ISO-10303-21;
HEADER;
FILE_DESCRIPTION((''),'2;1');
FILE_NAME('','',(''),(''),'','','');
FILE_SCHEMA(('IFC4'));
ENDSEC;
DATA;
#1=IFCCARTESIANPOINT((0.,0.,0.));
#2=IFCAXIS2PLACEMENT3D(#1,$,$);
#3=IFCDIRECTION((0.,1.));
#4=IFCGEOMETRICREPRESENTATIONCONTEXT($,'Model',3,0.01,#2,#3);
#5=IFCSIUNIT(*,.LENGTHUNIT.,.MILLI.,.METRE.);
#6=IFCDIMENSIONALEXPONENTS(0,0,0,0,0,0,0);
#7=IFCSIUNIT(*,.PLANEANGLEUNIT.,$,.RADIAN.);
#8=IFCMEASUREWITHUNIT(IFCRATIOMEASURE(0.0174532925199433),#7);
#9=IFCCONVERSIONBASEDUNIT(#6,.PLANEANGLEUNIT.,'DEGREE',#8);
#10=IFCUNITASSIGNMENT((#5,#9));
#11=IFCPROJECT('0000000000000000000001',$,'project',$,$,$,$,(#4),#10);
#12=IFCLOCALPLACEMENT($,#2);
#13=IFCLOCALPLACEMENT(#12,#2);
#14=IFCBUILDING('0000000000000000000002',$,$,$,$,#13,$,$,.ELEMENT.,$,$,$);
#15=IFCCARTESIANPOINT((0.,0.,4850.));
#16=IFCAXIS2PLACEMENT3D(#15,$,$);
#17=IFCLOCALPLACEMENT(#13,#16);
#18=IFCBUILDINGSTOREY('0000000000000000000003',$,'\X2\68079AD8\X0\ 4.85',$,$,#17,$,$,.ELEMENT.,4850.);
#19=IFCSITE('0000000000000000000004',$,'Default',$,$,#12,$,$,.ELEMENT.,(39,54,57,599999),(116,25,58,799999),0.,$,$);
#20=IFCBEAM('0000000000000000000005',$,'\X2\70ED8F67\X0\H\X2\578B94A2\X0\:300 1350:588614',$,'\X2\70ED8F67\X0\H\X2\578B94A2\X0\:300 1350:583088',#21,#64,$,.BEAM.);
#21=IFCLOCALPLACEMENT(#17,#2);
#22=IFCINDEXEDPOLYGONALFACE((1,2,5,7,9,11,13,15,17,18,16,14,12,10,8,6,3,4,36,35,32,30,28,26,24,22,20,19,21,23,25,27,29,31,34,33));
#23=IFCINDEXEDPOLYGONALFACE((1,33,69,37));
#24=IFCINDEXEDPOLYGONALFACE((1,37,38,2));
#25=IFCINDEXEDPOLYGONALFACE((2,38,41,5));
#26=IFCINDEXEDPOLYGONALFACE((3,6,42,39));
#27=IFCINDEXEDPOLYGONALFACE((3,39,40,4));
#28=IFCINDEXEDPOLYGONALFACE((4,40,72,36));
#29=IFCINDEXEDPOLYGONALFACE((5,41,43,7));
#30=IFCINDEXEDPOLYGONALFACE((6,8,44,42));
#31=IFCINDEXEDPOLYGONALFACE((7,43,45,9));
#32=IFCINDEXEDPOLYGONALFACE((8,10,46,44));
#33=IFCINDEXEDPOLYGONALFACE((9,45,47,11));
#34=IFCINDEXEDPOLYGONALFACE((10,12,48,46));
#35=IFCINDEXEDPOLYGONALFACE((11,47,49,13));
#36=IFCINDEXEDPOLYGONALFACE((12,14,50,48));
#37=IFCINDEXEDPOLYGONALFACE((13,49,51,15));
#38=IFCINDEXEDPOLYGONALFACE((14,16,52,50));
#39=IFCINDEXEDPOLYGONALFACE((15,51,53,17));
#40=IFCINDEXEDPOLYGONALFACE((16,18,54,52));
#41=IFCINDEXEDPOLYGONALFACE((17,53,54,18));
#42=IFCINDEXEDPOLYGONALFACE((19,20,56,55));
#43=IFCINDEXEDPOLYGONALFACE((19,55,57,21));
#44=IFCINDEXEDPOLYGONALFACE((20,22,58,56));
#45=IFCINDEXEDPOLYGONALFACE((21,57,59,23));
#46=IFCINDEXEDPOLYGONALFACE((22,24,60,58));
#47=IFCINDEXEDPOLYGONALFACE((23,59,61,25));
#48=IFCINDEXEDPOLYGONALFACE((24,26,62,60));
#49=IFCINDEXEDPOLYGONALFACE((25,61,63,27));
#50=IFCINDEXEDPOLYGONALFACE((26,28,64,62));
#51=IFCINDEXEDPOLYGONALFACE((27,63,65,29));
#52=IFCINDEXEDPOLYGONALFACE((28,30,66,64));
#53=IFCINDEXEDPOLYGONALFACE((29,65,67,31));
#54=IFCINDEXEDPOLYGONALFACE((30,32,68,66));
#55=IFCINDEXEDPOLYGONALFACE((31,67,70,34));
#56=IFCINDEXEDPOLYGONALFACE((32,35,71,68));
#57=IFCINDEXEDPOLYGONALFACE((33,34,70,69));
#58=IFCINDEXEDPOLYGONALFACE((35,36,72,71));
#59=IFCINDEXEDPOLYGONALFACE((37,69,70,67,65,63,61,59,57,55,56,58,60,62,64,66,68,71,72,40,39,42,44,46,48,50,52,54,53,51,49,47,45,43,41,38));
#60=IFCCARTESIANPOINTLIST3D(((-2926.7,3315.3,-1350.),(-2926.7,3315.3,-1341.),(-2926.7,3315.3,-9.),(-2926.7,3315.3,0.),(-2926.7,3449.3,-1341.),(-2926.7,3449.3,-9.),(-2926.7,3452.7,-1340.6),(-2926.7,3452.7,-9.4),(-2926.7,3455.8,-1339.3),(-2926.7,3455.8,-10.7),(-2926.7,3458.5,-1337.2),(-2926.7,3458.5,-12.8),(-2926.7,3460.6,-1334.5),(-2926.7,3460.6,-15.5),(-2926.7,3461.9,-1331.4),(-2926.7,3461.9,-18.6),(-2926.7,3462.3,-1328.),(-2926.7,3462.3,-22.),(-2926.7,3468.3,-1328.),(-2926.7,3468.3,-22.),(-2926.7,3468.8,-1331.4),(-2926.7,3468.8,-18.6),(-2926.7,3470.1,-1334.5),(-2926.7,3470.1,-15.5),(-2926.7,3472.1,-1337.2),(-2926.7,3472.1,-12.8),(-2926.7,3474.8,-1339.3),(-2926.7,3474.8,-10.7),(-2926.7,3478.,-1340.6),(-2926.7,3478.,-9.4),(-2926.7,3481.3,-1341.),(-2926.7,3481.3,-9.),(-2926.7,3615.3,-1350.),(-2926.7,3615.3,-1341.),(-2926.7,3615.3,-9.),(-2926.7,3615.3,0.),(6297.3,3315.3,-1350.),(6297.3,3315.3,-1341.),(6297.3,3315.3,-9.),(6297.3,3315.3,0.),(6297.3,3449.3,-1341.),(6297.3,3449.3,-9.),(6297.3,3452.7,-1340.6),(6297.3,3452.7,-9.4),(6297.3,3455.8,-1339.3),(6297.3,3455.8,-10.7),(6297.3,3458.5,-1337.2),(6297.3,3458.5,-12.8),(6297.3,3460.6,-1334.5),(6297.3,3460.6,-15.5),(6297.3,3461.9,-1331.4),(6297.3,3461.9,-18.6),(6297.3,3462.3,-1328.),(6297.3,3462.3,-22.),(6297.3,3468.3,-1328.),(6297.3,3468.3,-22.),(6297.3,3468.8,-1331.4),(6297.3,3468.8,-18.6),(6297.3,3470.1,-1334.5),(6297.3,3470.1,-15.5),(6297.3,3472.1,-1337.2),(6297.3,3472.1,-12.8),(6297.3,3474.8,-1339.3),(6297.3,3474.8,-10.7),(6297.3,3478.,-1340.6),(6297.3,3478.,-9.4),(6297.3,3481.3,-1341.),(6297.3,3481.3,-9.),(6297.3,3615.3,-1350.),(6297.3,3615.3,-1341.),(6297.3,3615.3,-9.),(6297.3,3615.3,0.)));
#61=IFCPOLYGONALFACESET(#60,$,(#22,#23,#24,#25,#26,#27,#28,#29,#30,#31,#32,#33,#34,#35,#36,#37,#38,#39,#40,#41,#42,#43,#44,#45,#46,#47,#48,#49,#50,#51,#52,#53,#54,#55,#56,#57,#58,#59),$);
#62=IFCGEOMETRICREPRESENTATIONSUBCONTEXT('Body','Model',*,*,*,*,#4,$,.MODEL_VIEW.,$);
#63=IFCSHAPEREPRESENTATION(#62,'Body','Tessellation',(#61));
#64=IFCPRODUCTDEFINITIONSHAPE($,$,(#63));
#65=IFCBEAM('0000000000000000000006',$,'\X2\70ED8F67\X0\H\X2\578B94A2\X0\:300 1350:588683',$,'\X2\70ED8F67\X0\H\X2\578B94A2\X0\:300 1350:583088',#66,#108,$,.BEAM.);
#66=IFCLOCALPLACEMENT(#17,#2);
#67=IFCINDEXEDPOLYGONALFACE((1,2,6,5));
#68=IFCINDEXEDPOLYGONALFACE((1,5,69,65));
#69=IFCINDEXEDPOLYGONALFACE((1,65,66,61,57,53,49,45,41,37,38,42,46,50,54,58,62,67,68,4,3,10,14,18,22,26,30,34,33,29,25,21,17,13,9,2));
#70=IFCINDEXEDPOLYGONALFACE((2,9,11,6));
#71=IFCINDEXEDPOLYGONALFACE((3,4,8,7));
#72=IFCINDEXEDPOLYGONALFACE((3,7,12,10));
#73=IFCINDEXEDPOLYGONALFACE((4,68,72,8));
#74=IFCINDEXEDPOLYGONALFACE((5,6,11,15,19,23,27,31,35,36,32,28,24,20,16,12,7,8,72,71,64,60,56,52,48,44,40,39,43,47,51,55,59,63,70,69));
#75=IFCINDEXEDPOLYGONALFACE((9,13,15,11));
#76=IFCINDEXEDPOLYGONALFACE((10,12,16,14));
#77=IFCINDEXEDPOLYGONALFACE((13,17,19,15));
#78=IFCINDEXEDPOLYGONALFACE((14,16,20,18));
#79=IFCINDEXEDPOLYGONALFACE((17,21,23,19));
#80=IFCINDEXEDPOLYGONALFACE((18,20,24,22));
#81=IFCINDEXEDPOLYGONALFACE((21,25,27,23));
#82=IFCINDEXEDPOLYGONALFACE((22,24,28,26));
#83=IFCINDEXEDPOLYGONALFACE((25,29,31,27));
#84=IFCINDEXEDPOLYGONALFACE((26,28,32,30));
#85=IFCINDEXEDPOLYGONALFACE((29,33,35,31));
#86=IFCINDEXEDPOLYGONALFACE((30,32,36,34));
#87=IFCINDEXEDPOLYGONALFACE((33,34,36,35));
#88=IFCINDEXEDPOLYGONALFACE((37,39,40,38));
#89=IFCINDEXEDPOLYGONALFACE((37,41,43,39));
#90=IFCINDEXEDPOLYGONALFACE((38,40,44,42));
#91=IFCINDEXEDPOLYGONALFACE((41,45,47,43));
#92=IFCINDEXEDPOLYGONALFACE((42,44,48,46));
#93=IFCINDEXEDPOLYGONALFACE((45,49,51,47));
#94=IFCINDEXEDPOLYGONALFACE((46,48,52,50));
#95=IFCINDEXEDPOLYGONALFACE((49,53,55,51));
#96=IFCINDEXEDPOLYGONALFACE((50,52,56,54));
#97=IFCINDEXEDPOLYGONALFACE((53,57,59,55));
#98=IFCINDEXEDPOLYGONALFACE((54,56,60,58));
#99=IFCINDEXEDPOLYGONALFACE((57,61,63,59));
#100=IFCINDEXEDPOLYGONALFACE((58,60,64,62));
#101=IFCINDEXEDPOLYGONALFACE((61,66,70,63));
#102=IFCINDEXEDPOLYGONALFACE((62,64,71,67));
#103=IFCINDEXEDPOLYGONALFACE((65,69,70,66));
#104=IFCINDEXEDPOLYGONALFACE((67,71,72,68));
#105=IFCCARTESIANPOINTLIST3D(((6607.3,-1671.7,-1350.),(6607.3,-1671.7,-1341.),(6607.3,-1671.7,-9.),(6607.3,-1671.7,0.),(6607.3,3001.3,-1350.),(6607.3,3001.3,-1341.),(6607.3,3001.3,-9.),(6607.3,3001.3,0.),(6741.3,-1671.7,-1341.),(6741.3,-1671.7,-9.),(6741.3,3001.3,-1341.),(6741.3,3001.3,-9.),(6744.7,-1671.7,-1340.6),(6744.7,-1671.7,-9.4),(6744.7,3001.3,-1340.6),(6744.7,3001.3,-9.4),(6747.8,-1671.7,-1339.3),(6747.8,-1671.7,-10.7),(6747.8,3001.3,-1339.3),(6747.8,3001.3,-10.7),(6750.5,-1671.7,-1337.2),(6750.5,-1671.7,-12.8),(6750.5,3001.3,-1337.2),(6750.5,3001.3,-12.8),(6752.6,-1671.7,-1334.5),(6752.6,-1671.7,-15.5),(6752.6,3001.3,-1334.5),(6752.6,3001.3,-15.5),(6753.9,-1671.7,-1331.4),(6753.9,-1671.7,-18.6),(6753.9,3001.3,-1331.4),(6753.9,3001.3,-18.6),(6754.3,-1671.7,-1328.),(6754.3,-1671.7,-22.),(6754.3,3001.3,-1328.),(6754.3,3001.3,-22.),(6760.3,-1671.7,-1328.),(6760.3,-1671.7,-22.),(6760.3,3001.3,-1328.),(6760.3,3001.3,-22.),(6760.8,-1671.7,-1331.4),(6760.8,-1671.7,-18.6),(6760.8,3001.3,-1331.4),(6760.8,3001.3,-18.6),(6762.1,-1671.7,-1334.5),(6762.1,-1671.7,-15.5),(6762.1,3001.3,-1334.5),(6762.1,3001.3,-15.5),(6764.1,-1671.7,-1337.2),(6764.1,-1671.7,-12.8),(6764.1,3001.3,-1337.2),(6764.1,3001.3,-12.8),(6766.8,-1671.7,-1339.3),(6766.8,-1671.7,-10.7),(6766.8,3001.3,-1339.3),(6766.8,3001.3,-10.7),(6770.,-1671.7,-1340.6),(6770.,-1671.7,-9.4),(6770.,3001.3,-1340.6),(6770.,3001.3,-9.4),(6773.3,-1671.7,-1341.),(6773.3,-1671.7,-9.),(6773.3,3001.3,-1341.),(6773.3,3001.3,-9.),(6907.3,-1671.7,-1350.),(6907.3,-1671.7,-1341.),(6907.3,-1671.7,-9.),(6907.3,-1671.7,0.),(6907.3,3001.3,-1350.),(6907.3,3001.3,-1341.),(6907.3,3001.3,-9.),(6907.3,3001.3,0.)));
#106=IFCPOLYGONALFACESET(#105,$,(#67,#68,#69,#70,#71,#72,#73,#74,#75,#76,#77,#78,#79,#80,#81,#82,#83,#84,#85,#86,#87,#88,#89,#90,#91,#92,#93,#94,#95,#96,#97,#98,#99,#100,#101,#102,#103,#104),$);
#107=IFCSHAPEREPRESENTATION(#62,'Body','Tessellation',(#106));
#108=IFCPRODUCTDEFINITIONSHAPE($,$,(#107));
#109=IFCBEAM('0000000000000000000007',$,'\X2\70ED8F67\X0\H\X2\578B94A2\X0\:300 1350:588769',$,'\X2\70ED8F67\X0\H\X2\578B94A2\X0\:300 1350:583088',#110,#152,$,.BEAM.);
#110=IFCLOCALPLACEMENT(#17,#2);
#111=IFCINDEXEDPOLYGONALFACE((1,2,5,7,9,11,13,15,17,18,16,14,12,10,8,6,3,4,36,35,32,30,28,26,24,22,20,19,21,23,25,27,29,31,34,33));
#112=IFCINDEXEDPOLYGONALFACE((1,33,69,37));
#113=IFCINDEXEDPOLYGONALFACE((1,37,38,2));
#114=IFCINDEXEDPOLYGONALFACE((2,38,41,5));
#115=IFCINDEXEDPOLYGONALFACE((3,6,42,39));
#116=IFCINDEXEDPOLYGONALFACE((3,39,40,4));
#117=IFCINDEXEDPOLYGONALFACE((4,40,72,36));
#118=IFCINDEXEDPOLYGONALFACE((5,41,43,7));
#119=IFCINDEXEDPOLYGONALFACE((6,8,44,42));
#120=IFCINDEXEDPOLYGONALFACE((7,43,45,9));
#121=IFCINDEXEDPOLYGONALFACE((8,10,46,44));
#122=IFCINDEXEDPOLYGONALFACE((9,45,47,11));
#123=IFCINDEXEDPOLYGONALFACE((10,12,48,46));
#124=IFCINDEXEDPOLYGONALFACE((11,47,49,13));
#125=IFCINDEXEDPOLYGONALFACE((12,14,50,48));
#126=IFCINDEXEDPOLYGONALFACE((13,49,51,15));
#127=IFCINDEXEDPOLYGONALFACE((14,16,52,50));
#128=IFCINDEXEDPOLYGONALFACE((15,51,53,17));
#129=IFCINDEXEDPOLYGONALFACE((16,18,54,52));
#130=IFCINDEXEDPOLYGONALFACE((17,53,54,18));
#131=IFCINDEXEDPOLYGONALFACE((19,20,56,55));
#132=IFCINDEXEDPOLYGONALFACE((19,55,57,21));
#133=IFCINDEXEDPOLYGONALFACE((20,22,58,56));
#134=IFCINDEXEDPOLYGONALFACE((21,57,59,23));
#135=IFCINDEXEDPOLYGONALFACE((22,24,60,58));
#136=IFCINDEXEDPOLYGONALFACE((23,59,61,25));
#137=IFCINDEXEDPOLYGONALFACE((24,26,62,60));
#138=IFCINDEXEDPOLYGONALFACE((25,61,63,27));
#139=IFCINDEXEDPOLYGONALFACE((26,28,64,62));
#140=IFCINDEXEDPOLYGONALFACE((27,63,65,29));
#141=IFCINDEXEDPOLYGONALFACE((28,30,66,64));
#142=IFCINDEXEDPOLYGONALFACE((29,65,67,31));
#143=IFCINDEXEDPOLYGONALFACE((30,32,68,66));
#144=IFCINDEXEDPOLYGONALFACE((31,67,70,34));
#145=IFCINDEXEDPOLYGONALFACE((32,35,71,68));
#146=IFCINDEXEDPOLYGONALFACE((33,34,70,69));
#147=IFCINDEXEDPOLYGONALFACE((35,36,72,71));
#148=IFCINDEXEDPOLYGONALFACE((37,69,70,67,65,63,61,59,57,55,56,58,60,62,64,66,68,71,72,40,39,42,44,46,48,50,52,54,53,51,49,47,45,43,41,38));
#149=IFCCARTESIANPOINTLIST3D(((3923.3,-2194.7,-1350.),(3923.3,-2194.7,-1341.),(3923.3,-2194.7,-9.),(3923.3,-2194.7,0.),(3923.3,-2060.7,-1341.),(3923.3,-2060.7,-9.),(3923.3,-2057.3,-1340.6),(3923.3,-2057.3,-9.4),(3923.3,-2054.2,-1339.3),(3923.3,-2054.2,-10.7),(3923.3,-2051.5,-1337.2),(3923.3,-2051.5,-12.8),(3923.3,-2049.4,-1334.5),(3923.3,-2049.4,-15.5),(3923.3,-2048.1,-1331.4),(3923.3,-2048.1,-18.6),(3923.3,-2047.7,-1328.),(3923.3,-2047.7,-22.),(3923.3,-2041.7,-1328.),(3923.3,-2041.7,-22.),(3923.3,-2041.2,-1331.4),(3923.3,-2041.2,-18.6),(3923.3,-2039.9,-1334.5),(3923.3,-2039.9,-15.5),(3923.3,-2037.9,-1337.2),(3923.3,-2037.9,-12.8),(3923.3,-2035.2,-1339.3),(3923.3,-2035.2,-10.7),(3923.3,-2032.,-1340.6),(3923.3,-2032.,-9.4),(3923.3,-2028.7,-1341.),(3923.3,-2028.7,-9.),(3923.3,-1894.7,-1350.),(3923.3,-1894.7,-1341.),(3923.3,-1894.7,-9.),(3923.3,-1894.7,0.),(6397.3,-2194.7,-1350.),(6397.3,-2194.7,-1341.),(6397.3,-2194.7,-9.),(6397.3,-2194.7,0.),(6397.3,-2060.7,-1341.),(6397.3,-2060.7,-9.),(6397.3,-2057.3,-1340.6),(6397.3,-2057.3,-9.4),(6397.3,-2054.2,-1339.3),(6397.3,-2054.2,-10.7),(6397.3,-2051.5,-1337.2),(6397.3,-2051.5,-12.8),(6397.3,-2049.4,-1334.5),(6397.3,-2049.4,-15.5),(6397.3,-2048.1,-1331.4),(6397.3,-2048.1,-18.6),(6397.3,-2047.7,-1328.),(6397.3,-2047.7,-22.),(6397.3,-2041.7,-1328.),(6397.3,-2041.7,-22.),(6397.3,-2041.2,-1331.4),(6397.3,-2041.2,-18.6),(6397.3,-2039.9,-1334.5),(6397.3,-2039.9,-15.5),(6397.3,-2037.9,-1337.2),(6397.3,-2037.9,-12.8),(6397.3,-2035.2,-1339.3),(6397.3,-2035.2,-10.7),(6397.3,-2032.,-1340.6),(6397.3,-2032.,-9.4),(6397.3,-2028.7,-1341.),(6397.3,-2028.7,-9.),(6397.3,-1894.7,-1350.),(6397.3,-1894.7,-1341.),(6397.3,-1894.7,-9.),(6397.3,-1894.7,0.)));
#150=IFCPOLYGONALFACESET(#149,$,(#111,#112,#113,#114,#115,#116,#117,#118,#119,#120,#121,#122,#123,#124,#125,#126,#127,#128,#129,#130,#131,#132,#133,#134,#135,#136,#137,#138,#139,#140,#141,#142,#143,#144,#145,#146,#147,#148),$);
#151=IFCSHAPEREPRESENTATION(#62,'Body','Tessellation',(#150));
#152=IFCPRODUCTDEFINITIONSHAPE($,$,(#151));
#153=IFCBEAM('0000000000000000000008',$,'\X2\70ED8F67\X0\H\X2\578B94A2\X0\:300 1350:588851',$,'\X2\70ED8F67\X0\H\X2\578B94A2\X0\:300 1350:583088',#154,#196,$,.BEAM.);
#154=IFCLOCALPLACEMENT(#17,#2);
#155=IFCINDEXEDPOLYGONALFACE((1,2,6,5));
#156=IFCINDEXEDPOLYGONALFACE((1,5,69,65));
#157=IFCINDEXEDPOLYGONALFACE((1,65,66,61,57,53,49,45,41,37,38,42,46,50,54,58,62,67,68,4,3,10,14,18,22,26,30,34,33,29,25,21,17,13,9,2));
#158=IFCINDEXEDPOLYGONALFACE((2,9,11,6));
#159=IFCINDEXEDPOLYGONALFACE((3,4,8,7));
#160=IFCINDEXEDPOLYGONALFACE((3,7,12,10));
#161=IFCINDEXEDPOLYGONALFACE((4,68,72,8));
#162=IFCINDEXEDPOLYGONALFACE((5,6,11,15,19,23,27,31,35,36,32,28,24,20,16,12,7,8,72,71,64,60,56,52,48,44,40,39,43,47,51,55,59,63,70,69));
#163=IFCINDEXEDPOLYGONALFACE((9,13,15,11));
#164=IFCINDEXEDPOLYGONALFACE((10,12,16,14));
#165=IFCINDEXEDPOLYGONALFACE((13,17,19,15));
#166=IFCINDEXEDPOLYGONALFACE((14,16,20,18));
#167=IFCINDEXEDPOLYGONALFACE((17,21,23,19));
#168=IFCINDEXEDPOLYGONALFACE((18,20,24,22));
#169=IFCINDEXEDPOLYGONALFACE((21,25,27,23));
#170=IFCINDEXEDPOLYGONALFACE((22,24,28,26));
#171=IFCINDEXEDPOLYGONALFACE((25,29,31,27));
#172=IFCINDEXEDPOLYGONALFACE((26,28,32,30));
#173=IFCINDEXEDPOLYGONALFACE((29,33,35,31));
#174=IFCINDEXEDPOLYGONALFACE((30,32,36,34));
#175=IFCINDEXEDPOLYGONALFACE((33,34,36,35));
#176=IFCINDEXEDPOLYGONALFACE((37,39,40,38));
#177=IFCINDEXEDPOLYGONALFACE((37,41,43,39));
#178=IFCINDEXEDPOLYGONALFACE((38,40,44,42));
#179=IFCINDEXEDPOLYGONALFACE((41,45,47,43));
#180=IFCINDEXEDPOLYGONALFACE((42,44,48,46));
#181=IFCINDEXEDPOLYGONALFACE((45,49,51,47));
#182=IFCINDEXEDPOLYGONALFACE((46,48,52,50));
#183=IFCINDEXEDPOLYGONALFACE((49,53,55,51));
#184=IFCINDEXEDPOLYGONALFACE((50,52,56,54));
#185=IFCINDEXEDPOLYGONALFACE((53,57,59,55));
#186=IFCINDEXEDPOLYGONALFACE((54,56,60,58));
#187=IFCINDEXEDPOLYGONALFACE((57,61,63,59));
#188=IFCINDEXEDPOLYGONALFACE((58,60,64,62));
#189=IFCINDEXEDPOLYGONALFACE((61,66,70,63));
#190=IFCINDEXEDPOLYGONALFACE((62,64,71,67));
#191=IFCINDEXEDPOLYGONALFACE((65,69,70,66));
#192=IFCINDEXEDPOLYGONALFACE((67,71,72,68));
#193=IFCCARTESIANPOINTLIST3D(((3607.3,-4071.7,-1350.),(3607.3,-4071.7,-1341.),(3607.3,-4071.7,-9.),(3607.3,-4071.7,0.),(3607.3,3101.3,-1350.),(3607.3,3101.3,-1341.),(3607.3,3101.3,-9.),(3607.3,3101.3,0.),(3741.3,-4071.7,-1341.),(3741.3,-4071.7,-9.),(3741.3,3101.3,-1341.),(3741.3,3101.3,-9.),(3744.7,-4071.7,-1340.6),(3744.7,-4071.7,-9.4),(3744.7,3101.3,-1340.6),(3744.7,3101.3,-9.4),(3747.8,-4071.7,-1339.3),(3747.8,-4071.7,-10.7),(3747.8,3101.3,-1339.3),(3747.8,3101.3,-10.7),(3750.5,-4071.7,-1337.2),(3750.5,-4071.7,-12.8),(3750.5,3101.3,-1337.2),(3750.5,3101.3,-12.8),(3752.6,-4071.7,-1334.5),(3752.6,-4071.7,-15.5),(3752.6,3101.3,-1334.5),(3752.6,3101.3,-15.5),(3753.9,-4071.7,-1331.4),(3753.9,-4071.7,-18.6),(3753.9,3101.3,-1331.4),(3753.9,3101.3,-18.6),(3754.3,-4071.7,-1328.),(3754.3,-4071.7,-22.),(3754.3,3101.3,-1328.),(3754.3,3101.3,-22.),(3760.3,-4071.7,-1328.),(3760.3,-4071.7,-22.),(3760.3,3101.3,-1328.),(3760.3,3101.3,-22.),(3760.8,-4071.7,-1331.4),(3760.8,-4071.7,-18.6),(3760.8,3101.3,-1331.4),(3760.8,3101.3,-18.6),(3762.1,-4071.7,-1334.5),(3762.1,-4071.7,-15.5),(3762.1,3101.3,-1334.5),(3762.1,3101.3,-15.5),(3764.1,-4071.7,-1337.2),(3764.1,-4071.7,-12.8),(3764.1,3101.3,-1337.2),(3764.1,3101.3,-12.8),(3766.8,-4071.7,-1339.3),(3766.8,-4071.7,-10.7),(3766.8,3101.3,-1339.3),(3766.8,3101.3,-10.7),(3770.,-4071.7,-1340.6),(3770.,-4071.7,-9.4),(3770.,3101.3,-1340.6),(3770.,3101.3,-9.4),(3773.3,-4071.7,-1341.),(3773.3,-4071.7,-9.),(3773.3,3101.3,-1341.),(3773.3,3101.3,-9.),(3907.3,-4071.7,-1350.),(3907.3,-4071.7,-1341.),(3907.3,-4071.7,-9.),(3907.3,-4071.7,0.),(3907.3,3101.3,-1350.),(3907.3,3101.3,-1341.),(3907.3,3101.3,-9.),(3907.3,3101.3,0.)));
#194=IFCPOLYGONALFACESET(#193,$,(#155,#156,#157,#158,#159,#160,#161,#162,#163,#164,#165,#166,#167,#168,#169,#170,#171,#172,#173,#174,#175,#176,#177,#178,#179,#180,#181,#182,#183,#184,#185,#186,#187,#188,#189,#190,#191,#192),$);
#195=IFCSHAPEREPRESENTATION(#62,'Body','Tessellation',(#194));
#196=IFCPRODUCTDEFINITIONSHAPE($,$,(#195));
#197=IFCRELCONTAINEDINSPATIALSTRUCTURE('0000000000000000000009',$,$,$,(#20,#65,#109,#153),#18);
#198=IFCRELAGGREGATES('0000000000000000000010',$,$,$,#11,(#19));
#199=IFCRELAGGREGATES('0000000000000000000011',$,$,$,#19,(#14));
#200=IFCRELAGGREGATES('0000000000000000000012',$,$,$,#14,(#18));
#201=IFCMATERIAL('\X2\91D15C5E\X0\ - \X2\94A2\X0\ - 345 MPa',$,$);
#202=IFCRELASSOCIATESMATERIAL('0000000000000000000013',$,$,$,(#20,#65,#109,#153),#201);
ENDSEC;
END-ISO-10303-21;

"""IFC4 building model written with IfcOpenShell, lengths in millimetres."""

from ifc_helpers import new_model, entity, si_unit, converted_unit, direction, frame, frame_2d, origin, place, context, subcontext, project, spatial, i_section, extrude, material, element, save


model = new_model("IFC4")

# Units and contexts
model_context = context("Model", 3, precision=0.01, world=origin(), true_north=direction((0.0, 1.0)))
body_context = subcontext(model_context, "Body", "Model", "MODEL_VIEW")
ifc_project = project(units=[si_unit("LENGTHUNIT", "METRE", prefix="MILLI"), converted_unit("PLANEANGLEUNIT", "DEGREE", entity("IfcRatioMeasure", 0.0174532925199433), si_unit("PLANEANGLEUNIT", "RADIAN"), dimensions=[0, 0, 0, 0, 0, 0, 0])], contexts=[model_context])

# Site, building, storey
site_placement = place(None, origin())
site = spatial("IfcSite", under=ifc_project, at=site_placement, Name="Default", CompositionType="ELEMENT", RefLatitude=(39, 54, 57, 599999), RefLongitude=(116, 25, 58, 799999), RefElevation=0.0)
building_placement = place(site_placement, origin())
building = spatial("IfcBuilding", under=site, at=building_placement, CompositionType="ELEMENT")
storey_placement = place(building_placement, frame((0.0, 0.0, 4850.0)))
storey = spatial("IfcBuildingStorey", under=building, at=storey_placement, Name="标高 4.85", CompositionType="ELEMENT", Elevation=4850.0)

# Beams
ifc_material_1 = material(Name="金属 - 钢 - 345 MPa")
beam_1_placement = place(storey_placement, frame((-2953.7, 3465.3, 0.0)))
element("IfcBeam", 1, at=beam_1_placement, inside=storey, material=ifc_material_1, Name="热轧H型钢:300 1350:588614", ObjectType="热轧H型钢:300 1350:583088", PredefinedType="BEAM", context=body_context, shape_type="SweptSolid", body=[
    extrude(i_section(OverallWidth=300.0, OverallDepth=1350.0, WebThickness=6.0, FlangeThickness=9.0, FilletRadius=13.0, at=frame_2d((0.0, 0.0), x_axis=(0.0, 1.0))), frame((27.0, 0.0, -675.0), z_axis=(1.0, 0.0, 0.0), x_axis=(0.0, 0.0, -1.0)), (0.0, 0.0, 1.0), 9224.0),
])
beam_2_placement = place(storey_placement, frame((6757.3, 3015.3, 0.0), z_axis=(0.0, 0.0, 1.0), x_axis=(0.0, -1.0, 0.0)))
element("IfcBeam", 2, at=beam_2_placement, inside=storey, material=ifc_material_1, Name="热轧H型钢:300 1350:588683", ObjectType="热轧H型钢:300 1350:583088", PredefinedType="BEAM", context=body_context, shape_type="SweptSolid", body=[
    extrude(i_section(OverallWidth=300.0, OverallDepth=1350.0, WebThickness=6.0, FlangeThickness=9.0, FilletRadius=13.0, at=frame_2d((0.0, 0.0), x_axis=(0.0, 1.0))), frame((14.0, 0.0, -675.0), z_axis=(1.0, 0.0, 0.0), x_axis=(0.0, 0.0, -1.0)), (0.0, 0.0, 1.0), 4673.0),
])
beam_3_placement = place(storey_placement, frame((6396.3, -2044.7, 0.0), z_axis=(0.0, 0.0, 1.0), x_axis=(-1.0, 0.0, 0.0)))
element("IfcBeam", 3, at=beam_3_placement, inside=storey, material=ifc_material_1, Name="热轧H型钢:300 1350:588769", ObjectType="热轧H型钢:300 1350:583088", PredefinedType="BEAM", context=body_context, shape_type="SweptSolid", body=[
    extrude(i_section(OverallWidth=300.0, OverallDepth=1350.0, WebThickness=6.0, FlangeThickness=9.0, FilletRadius=13.0, at=frame_2d((0.0, 0.0), x_axis=(0.0, 1.0))), frame((-1.0, 0.0, -675.0), z_axis=(1.0, 0.0, 0.0), x_axis=(0.0, 0.0, -1.0)), (0.0, 0.0, 1.0), 2474.0),
])
beam_4_placement = place(storey_placement, frame((3757.3, 3115.3, 0.0), z_axis=(0.0, 0.0, 1.0), x_axis=(0.0, -1.0, 0.0)))
element("IfcBeam", 4, at=beam_4_placement, inside=storey, material=ifc_material_1, Name="热轧H型钢:300 1350:588851", ObjectType="热轧H型钢:300 1350:583088", PredefinedType="BEAM", context=body_context, shape_type="SweptSolid", body=[
    extrude(i_section(OverallWidth=300.0, OverallDepth=1350.0, WebThickness=6.0, FlangeThickness=9.0, FilletRadius=13.0, at=frame_2d((0.0, 0.0), x_axis=(0.0, 1.0))), frame((14.0, 0.0, -675.0), z_axis=(1.0, 0.0, 0.0), x_axis=(0.0, 0.0, -1.0)), (0.0, 0.0, 1.0), 7173.0),
])

save(model, "model.ifc")
